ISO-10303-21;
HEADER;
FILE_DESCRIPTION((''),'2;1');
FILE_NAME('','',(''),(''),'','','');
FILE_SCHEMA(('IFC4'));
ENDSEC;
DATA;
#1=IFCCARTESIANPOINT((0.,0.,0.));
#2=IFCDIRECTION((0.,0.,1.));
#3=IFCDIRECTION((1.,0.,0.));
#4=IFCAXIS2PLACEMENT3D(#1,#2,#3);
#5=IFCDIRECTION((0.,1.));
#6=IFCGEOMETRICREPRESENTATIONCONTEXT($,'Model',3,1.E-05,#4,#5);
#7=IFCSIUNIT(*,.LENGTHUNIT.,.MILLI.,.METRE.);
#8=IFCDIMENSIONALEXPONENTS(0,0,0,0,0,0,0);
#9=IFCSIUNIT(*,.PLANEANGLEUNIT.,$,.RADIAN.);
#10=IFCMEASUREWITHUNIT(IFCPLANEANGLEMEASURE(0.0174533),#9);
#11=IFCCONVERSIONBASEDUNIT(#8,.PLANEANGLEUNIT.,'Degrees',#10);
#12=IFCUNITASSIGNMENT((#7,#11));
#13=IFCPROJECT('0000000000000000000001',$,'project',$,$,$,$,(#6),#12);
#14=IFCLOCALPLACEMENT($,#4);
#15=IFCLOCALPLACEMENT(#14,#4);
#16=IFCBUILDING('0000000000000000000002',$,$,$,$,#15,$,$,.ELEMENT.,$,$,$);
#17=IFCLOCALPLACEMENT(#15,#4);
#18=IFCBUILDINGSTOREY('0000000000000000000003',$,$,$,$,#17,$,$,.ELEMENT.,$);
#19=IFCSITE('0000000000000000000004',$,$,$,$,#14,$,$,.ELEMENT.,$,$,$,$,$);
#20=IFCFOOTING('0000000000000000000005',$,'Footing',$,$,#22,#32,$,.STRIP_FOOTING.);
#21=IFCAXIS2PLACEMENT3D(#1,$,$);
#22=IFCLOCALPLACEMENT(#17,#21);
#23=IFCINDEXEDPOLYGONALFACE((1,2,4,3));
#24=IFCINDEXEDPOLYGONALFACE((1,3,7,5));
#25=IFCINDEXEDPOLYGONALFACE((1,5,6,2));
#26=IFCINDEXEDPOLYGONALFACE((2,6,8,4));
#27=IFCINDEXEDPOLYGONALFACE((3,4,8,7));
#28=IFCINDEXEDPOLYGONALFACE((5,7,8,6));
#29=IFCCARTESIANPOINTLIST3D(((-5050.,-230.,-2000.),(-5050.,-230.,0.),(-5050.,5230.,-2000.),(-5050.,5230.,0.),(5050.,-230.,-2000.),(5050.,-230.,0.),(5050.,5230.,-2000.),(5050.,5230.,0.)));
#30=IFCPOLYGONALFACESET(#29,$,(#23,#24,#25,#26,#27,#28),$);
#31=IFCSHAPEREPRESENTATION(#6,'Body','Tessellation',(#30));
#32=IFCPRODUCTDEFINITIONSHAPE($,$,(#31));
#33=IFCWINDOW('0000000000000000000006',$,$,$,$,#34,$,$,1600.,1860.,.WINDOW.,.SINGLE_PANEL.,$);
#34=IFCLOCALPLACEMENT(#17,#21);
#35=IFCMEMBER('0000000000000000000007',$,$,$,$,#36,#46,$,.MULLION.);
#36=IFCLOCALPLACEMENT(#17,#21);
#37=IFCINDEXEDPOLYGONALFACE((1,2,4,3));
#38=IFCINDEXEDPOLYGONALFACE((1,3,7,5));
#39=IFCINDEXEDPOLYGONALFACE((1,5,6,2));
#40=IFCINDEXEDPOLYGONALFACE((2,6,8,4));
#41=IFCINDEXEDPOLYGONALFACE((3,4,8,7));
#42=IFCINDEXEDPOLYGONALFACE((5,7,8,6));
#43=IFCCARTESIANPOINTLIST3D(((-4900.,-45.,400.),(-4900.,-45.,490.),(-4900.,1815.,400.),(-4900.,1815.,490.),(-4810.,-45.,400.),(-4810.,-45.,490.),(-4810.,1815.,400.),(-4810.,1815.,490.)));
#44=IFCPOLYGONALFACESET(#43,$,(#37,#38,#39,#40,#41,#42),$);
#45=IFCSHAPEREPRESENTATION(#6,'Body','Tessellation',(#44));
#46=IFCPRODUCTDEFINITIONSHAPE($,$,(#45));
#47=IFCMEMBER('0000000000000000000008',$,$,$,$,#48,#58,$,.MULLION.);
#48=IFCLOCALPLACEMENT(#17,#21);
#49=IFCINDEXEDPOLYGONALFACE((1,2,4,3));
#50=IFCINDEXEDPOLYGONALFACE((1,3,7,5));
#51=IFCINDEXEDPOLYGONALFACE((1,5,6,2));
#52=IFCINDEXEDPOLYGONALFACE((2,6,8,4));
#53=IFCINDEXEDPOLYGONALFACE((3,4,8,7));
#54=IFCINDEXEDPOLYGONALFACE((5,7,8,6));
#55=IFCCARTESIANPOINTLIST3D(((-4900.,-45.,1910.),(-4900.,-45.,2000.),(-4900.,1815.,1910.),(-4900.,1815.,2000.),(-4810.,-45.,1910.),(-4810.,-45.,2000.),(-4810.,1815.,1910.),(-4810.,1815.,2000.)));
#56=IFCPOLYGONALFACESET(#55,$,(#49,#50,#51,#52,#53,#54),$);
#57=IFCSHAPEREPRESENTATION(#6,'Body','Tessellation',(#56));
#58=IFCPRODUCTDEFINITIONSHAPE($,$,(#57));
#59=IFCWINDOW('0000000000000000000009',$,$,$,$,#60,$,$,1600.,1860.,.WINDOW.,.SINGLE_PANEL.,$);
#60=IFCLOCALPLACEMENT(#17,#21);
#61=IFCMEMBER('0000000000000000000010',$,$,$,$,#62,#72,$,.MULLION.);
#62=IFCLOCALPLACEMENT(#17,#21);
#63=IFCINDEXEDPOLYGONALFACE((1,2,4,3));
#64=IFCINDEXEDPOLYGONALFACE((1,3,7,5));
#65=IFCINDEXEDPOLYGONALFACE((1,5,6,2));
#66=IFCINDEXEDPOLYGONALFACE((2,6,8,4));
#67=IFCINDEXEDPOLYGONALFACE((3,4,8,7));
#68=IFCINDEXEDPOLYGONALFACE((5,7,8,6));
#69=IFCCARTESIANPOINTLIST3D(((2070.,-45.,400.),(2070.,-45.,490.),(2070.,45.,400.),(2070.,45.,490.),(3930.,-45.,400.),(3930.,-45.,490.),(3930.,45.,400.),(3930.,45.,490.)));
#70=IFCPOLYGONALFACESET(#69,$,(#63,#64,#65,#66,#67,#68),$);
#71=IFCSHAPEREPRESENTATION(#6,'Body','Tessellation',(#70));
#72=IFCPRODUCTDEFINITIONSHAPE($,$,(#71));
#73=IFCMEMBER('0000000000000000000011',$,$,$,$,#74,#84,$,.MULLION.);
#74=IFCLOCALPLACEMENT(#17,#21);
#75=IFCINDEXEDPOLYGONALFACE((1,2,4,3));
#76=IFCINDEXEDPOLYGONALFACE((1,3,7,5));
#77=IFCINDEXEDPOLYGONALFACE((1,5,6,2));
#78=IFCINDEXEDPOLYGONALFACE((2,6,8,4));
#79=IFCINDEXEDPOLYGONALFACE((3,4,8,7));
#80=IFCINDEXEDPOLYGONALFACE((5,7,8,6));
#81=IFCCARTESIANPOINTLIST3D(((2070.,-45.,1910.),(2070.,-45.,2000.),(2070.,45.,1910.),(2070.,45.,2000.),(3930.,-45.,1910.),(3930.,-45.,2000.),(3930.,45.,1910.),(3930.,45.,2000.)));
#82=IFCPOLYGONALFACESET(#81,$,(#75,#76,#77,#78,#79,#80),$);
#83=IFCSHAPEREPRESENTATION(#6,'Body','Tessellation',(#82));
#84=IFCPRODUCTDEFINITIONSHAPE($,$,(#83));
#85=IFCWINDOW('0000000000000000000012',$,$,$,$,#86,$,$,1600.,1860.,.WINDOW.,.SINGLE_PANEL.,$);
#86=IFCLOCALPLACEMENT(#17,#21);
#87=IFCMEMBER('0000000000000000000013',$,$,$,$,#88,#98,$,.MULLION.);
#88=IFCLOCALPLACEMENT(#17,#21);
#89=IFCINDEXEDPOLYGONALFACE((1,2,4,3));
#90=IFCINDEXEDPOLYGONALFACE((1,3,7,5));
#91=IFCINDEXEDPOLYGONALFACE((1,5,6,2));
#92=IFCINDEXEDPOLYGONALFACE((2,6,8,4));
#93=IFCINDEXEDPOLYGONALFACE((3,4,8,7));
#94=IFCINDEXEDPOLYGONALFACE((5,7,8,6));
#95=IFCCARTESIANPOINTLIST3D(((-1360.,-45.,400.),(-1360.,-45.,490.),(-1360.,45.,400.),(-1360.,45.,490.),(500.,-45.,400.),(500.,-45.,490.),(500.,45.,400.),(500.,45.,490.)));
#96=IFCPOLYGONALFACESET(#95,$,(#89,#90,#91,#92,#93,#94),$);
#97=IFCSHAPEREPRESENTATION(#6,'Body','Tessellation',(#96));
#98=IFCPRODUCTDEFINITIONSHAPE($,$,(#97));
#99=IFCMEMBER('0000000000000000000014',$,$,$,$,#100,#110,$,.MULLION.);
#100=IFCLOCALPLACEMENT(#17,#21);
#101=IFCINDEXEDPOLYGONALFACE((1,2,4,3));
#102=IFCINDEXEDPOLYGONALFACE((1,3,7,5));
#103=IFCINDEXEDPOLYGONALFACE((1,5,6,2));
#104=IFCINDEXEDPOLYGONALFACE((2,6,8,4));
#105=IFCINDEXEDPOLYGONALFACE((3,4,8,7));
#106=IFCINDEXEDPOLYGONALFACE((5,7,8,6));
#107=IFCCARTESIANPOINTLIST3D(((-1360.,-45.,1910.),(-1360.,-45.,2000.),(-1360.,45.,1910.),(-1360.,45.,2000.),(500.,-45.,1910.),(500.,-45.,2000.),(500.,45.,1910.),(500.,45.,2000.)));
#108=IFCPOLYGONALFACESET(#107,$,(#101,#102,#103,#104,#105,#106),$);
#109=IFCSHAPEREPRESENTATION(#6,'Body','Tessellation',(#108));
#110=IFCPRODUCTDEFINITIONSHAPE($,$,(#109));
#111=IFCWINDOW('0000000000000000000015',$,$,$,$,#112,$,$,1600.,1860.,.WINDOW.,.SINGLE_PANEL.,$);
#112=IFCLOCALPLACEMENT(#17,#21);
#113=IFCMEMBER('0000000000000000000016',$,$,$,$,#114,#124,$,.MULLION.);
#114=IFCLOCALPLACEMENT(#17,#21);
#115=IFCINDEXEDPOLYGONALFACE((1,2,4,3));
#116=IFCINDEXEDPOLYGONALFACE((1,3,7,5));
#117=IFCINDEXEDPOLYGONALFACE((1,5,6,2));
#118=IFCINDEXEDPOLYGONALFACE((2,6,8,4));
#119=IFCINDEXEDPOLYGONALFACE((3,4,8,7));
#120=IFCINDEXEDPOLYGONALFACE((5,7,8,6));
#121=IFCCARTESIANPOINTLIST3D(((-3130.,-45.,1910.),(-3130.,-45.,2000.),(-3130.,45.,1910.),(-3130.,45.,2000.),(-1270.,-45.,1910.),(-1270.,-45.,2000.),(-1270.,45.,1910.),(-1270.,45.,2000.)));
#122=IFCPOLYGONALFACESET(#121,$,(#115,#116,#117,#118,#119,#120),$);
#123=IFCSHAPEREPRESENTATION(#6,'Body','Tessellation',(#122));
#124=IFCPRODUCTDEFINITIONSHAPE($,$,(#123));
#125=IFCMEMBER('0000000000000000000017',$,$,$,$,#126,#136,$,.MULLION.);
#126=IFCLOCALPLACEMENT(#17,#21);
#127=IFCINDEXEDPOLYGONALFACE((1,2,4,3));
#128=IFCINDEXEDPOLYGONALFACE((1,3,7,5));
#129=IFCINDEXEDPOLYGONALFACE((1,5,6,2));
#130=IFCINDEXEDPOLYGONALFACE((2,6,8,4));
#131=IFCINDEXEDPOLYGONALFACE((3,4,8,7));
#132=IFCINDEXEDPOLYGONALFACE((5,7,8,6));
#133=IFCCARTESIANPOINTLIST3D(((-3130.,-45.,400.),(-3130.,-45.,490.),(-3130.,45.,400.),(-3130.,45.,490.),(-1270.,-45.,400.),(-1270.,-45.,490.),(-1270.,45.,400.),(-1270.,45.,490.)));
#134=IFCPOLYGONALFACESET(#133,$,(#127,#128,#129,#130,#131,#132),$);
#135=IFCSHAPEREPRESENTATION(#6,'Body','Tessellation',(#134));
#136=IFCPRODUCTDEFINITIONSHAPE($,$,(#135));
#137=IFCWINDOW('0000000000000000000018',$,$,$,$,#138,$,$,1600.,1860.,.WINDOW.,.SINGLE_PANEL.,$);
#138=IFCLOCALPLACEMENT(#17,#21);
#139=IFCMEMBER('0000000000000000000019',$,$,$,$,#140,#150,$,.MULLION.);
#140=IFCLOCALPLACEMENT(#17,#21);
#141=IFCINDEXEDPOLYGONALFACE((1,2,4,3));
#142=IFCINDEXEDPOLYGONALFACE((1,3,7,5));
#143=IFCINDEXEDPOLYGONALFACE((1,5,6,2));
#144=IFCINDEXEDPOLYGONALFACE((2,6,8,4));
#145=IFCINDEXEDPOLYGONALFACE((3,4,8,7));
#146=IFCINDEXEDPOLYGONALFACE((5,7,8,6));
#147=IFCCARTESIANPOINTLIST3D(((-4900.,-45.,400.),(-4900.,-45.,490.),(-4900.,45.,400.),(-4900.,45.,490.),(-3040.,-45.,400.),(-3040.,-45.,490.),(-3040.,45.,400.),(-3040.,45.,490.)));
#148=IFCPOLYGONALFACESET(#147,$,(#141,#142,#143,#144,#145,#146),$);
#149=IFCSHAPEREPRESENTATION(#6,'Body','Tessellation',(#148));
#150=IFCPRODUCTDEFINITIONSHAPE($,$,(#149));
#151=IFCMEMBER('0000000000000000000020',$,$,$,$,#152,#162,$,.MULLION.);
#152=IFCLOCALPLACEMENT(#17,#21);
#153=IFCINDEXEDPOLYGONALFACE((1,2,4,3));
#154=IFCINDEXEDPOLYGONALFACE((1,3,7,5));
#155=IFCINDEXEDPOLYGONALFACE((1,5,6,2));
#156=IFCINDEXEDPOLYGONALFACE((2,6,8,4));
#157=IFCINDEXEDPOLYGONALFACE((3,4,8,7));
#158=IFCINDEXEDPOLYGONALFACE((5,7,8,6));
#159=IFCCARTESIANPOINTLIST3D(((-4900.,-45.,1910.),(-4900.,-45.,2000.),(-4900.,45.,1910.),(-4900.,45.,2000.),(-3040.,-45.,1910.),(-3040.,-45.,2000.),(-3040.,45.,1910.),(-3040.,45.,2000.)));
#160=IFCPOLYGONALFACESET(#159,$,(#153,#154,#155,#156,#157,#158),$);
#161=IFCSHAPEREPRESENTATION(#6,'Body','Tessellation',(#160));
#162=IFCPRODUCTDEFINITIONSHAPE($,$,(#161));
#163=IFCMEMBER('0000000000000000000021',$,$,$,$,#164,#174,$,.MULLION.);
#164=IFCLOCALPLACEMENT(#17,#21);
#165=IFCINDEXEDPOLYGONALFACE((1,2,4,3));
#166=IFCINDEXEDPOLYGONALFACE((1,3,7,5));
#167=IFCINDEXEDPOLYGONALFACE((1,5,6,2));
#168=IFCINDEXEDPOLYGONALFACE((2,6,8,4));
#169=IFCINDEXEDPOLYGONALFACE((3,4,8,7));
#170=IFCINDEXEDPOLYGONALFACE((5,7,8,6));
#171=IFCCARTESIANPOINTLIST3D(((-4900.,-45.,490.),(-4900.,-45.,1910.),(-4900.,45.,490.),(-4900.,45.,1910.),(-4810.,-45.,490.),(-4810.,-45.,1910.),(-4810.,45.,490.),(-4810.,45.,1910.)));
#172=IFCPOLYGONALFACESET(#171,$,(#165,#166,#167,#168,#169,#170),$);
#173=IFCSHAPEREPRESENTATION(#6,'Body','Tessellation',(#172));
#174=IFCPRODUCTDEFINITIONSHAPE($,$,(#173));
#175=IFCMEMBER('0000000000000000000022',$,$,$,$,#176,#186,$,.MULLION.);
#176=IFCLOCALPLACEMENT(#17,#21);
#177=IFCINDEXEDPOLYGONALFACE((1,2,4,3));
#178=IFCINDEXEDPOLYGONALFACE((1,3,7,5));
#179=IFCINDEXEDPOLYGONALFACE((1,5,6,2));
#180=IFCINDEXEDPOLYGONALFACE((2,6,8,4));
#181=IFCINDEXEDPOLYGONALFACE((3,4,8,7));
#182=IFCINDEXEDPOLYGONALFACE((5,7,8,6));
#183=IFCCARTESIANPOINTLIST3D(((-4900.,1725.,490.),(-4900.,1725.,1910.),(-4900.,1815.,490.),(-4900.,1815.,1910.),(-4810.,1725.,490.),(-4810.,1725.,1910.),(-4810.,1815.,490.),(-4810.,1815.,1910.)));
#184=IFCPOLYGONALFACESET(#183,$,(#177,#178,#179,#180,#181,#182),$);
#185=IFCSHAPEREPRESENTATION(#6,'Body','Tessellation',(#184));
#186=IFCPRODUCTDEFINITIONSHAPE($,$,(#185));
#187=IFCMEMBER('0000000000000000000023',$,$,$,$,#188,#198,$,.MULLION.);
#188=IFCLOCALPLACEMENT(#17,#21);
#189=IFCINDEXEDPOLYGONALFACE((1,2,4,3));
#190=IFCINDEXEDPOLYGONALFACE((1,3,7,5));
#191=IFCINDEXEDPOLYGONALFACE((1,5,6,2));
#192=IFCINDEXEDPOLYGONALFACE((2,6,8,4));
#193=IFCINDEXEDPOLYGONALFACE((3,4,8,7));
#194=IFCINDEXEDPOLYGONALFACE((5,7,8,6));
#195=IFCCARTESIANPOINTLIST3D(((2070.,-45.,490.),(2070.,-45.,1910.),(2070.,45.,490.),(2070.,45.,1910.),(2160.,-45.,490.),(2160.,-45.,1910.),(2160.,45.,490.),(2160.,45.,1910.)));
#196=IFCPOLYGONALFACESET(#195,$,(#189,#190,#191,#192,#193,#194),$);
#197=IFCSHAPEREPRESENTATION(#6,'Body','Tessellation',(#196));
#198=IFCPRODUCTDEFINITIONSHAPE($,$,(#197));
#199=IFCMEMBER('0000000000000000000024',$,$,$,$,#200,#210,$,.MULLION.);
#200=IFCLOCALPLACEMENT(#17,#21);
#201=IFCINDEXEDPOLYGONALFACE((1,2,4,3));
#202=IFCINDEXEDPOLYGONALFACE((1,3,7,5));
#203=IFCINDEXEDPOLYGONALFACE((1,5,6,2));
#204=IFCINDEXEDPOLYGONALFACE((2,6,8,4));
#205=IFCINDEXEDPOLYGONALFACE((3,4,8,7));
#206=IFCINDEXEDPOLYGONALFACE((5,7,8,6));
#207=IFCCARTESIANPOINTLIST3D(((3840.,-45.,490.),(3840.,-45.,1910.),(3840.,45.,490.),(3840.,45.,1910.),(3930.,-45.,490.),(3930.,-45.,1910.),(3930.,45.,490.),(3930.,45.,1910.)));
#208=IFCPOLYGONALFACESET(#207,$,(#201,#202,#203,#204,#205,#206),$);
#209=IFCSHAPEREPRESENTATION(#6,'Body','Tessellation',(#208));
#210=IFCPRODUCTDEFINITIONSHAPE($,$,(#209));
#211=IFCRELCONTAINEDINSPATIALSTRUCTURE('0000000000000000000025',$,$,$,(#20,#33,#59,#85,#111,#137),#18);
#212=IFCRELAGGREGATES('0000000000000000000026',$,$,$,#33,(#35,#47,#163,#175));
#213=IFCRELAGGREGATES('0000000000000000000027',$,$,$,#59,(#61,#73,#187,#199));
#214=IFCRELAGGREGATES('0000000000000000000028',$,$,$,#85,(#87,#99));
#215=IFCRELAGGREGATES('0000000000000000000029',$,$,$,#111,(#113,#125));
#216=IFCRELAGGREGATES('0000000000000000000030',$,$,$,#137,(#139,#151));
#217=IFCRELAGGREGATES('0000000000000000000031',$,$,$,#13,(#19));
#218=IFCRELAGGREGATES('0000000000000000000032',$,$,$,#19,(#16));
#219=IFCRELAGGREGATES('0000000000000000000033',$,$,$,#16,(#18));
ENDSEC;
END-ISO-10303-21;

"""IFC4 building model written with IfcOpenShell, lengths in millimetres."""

from ifc_helpers import new_model, entity, si_unit, converted_unit, direction, frame, origin_with_axes, place, context, project, spatial, polyline, outline, extrude, source, transform, mapped, element, aggregate, save


model = new_model("IFC4")

# Units and contexts
model_context = context("Model", 3, precision=1e-05, world=origin_with_axes(), true_north=direction((0.0, 1.0)))
ifc_project = project(units=[si_unit("LENGTHUNIT", "METRE", prefix="MILLI"), converted_unit("PLANEANGLEUNIT", "Degrees", entity("IfcPlaneAngleMeasure", 0.0174533), si_unit("PLANEANGLEUNIT", "RADIAN"), dimensions=[0, 0, 0, 0, 0, 0, 0])], contexts=[model_context])

# Site, building, storey
site_placement = place(None, origin_with_axes())
site = spatial("IfcSite", under=ifc_project, at=site_placement, CompositionType="ELEMENT")
building_placement = place(site_placement, origin_with_axes())
building = spatial("IfcBuilding", under=site, at=building_placement, CompositionType="ELEMENT")
storey_placement = place(building_placement, origin_with_axes())
storey = spatial("IfcBuildingStorey", under=building, at=storey_placement, CompositionType="ELEMENT")

# Footing
footing_placement = place(storey_placement, frame((0.0, 2500.0, -2000.0), z_axis=(0.0, 0.0, 1.0), x_axis=(1.0, 0.0, 0.0)))
element("IfcFooting", 1, at=footing_placement, inside=storey, Name="Footing", PredefinedType="STRIP_FOOTING", context=model_context, shape_type="SweptSolid", body=[
    extrude(outline(polyline([(-5050.0, -2730.0), (5050.0, -2730.0), (5050.0, 2730.0), (-5050.0, 2730.0), (-5050.0, -2730.0), (-5050.0, -2730.0)])), origin_with_axes(), (0.0, 0.0, 1.0), 2000.0),
])

# Windows, members
window_1_placement = place(storey_placement, frame((-4810.0, -45.0, 400.0), z_axis=(0.0, 0.0, 1.0), x_axis=(0.0, 1.0, 0.0)))
window_1 = element("IfcWindow", 2, at=window_1_placement, inside=storey, OverallHeight=1600.0, OverallWidth=1860.0, PartitioningType="SINGLE_PANEL", PredefinedType="WINDOW")
shared_shape_1 = source(origin_with_axes(), model_context, "Body", "SweptSolid", [
    extrude(outline(polyline([(-930.0, -45.0), (930.0, -45.0), (930.0, 45.0), (-930.0, 45.0), (-930.0, -45.0), (-930.0, -45.0)])), origin_with_axes(), (0.0, 0.0, 1.0), 90.0),
])
member_1_placement = place(window_1_placement, frame((930.0, 45.0, 0.0), z_axis=(0.0, 0.0, 1.0), x_axis=(1.0, 0.0, 0.0)))
member_1 = element("IfcMember", 3, at=member_1_placement, PredefinedType="MULLION", context=model_context, shape_type="MappedRepresentation", body=[
    mapped(shared_shape_1, transform((0.0, 0.0, 0.0))),
])
member_2_placement = place(window_1_placement, frame((930.0, 45.0, 1510.0), z_axis=(0.0, 0.0, 1.0), x_axis=(1.0, 0.0, 0.0)))
member_2 = element("IfcMember", 4, at=member_2_placement, PredefinedType="MULLION", context=model_context, shape_type="MappedRepresentation", body=[
    mapped(shared_shape_1, transform((0.0, 0.0, 0.0))),
])
window_2_placement = place(storey_placement, frame((2070.0, -45.0, 400.0), z_axis=(0.0, 0.0, 1.0), x_axis=(1.0, 0.0, 0.0)))
window_2 = element("IfcWindow", 5, at=window_2_placement, inside=storey, OverallHeight=1600.0, OverallWidth=1860.0, PartitioningType="SINGLE_PANEL", PredefinedType="WINDOW")
member_3_placement = place(window_2_placement, frame((930.0, 45.0, 0.0), z_axis=(0.0, 0.0, 1.0), x_axis=(1.0, 0.0, 0.0)))
member_3 = element("IfcMember", 6, at=member_3_placement, PredefinedType="MULLION", context=model_context, shape_type="MappedRepresentation", body=[
    mapped(shared_shape_1, transform((0.0, 0.0, 0.0))),
])
member_4_placement = place(window_2_placement, frame((930.0, 45.0, 1510.0), z_axis=(0.0, 0.0, 1.0), x_axis=(1.0, 0.0, 0.0)))
member_4 = element("IfcMember", 7, at=member_4_placement, PredefinedType="MULLION", context=model_context, shape_type="MappedRepresentation", body=[
    mapped(shared_shape_1, transform((0.0, 0.0, 0.0))),
])
window_3_placement = place(storey_placement, frame((-1360.0, -45.0, 400.0), z_axis=(0.0, 0.0, 1.0), x_axis=(1.0, 0.0, 0.0)))
window_3 = element("IfcWindow", 8, at=window_3_placement, inside=storey, OverallHeight=1600.0, OverallWidth=1860.0, PartitioningType="SINGLE_PANEL", PredefinedType="WINDOW")
member_5_placement = place(window_3_placement, frame((930.0, 45.0, 0.0), z_axis=(0.0, 0.0, 1.0), x_axis=(1.0, 0.0, 0.0)))
member_5 = element("IfcMember", 9, at=member_5_placement, PredefinedType="MULLION", context=model_context, shape_type="MappedRepresentation", body=[
    mapped(shared_shape_1, transform((0.0, 0.0, 0.0))),
])
member_6_placement = place(window_3_placement, frame((930.0, 45.0, 1510.0), z_axis=(0.0, 0.0, 1.0), x_axis=(1.0, 0.0, 0.0)))
member_6 = element("IfcMember", 10, at=member_6_placement, PredefinedType="MULLION", context=model_context, shape_type="MappedRepresentation", body=[
    mapped(shared_shape_1, transform((0.0, 0.0, 0.0))),
])
window_4_placement = place(storey_placement, frame((-3130.0, -45.0, 400.0), z_axis=(0.0, 0.0, 1.0), x_axis=(1.0, 0.0, 0.0)))
window_4 = element("IfcWindow", 11, at=window_4_placement, inside=storey, OverallHeight=1600.0, OverallWidth=1860.0, PartitioningType="SINGLE_PANEL", PredefinedType="WINDOW")
member_7_placement = place(window_4_placement, frame((930.0, 45.0, 1510.0), z_axis=(0.0, 0.0, 1.0), x_axis=(1.0, 0.0, 0.0)))
member_7 = element("IfcMember", 12, at=member_7_placement, PredefinedType="MULLION", context=model_context, shape_type="MappedRepresentation", body=[
    mapped(shared_shape_1, transform((0.0, 0.0, 0.0))),
])
member_8_placement = place(window_4_placement, frame((930.0, 45.0, 0.0), z_axis=(0.0, 0.0, 1.0), x_axis=(1.0, 0.0, 0.0)))
member_8 = element("IfcMember", 13, at=member_8_placement, PredefinedType="MULLION", context=model_context, shape_type="MappedRepresentation", body=[
    mapped(shared_shape_1, transform((0.0, 0.0, 0.0))),
])
window_5_placement = place(storey_placement, frame((-4900.0, -45.0, 400.0), z_axis=(0.0, 0.0, 1.0), x_axis=(1.0, 0.0, 0.0)))
window_5 = element("IfcWindow", 14, at=window_5_placement, inside=storey, OverallHeight=1600.0, OverallWidth=1860.0, PartitioningType="SINGLE_PANEL", PredefinedType="WINDOW")
member_9_placement = place(window_5_placement, frame((930.0, 45.0, 0.0), z_axis=(0.0, 0.0, 1.0), x_axis=(1.0, 0.0, 0.0)))
member_9 = element("IfcMember", 15, at=member_9_placement, PredefinedType="MULLION", context=model_context, shape_type="MappedRepresentation", body=[
    mapped(shared_shape_1, transform((0.0, 0.0, 0.0))),
])
member_10_placement = place(window_5_placement, frame((930.0, 45.0, 1510.0), z_axis=(0.0, 0.0, 1.0), x_axis=(1.0, 0.0, 0.0)))
member_10 = element("IfcMember", 16, at=member_10_placement, PredefinedType="MULLION", context=model_context, shape_type="MappedRepresentation", body=[
    mapped(shared_shape_1, transform((0.0, 0.0, 0.0))),
])

# Members
shared_shape_2 = source(origin_with_axes(), model_context, "Body", "SweptSolid", [
    extrude(outline(polyline([(-45.0, -45.0), (45.0, -45.0), (45.0, 45.0), (-45.0, 45.0), (-45.0, -45.0), (-45.0, -45.0)])), origin_with_axes(), (0.0, 0.0, 1.0), 1420.0),
])
member_11_placement = place(window_1_placement, frame((45.0, 45.0, 90.0), z_axis=(0.0, 0.0, 1.0), x_axis=(1.0, 0.0, 0.0)))
member_11 = element("IfcMember", 17, at=member_11_placement, PredefinedType="MULLION", context=model_context, shape_type="MappedRepresentation", body=[
    mapped(shared_shape_2, transform((0.0, 0.0, 0.0))),
])
member_12_placement = place(window_1_placement, frame((1815.0, 45.0, 90.0), z_axis=(0.0, 0.0, 1.0), x_axis=(1.0, 0.0, 0.0)))
member_12 = element("IfcMember", 18, at=member_12_placement, PredefinedType="MULLION", context=model_context, shape_type="MappedRepresentation", body=[
    mapped(shared_shape_2, transform((0.0, 0.0, 0.0))),
])
member_13_placement = place(window_2_placement, frame((45.0, 45.0, 90.0), z_axis=(0.0, 0.0, 1.0), x_axis=(1.0, 0.0, 0.0)))
member_13 = element("IfcMember", 19, at=member_13_placement, PredefinedType="MULLION", context=model_context, shape_type="MappedRepresentation", body=[
    mapped(shared_shape_2, transform((0.0, 0.0, 0.0))),
])
member_14_placement = place(window_2_placement, frame((1815.0, 45.0, 90.0), z_axis=(0.0, 0.0, 1.0), x_axis=(1.0, 0.0, 0.0)))
member_14 = element("IfcMember", 20, at=member_14_placement, PredefinedType="MULLION", context=model_context, shape_type="MappedRepresentation", body=[
    mapped(shared_shape_2, transform((0.0, 0.0, 0.0))),
])

aggregate(window_1, [member_1, member_2, member_11, member_12])
aggregate(window_2, [member_3, member_4, member_13, member_14])
aggregate(window_3, [member_5, member_6])
aggregate(window_4, [member_7, member_8])
aggregate(window_5, [member_9, member_10])

save(model, "model.ifc")
